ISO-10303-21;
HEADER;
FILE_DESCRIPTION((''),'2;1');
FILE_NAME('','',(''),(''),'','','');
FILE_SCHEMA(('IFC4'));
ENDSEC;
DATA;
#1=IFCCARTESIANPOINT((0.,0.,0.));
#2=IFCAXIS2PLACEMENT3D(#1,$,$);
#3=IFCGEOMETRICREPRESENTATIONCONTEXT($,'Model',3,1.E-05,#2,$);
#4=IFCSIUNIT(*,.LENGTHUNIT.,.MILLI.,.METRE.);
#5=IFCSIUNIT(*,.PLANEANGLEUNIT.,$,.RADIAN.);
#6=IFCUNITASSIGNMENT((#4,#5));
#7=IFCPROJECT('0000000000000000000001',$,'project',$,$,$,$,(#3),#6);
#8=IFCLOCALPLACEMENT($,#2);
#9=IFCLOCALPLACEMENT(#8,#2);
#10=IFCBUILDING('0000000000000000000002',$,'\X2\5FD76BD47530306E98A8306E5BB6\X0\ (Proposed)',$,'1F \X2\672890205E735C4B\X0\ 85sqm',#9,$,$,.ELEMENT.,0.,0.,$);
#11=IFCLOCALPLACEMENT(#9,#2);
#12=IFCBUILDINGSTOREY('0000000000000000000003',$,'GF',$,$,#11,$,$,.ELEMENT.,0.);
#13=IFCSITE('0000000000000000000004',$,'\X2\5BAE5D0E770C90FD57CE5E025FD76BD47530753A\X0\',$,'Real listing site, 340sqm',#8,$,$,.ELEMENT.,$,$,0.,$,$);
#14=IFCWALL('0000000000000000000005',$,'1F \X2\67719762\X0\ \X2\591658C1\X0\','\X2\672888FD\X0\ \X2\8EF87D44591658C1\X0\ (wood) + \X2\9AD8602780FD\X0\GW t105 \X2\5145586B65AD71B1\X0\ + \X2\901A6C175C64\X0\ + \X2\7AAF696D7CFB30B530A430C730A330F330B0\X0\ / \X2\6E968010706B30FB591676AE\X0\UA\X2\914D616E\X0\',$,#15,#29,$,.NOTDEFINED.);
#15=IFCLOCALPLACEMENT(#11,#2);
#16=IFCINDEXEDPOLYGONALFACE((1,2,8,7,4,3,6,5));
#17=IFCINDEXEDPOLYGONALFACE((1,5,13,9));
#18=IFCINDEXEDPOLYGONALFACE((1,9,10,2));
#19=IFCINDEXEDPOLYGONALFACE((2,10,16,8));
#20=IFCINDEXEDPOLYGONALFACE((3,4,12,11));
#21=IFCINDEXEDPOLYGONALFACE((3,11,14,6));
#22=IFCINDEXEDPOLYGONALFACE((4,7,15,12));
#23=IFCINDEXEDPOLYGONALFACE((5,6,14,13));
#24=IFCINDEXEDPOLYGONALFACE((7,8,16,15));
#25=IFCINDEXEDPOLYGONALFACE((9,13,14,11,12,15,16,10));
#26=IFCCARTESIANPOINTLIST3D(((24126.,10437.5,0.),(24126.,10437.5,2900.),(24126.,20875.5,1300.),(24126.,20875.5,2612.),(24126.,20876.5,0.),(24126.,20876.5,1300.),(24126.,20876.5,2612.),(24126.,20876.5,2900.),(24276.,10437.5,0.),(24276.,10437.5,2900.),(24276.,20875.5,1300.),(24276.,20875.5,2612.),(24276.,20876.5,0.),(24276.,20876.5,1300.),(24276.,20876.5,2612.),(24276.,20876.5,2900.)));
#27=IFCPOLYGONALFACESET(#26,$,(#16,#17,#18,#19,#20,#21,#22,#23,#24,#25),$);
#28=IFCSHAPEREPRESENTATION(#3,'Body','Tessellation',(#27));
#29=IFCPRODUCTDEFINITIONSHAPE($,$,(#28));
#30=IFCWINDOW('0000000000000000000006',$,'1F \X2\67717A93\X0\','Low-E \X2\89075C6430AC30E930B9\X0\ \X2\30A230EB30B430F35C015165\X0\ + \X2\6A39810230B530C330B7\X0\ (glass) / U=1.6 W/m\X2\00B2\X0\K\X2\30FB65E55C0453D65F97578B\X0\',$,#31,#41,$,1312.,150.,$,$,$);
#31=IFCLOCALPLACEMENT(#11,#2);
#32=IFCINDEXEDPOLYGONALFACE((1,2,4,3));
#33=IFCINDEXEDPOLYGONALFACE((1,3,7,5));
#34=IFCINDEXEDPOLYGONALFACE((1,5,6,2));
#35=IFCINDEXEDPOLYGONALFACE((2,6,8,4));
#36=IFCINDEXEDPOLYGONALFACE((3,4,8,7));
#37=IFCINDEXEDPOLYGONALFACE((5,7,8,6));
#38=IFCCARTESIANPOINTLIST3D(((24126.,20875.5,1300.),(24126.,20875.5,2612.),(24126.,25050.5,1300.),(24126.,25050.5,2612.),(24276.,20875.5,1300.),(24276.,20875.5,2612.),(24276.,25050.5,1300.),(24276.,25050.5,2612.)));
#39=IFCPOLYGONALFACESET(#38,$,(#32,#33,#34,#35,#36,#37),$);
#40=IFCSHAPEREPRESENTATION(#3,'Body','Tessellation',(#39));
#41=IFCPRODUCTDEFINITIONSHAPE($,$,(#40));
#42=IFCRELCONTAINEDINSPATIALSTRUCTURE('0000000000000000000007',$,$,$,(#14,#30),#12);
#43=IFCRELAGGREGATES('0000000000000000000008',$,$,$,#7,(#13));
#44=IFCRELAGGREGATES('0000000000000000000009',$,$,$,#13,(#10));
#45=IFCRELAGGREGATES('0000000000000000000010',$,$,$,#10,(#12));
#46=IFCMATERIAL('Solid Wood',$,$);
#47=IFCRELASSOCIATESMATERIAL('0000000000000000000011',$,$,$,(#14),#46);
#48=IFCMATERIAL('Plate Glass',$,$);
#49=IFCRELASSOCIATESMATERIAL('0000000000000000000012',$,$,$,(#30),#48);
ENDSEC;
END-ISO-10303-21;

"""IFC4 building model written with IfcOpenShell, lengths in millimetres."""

from ifc_helpers import new_model, si_unit, frame, frame_2d, origin, place, context, project, spatial, rectangle, extrude, material, element, fill, save


model = new_model("IFC4")

# Units and contexts
model_context = context("Model", 3, precision=1e-05, world=origin())
ifc_project = project(units=[si_unit("LENGTHUNIT", "METRE", prefix="MILLI"), si_unit("PLANEANGLEUNIT", "RADIAN")], contexts=[model_context])

# Site, building, storey
site_placement = place(None, origin())
site = spatial("IfcSite", under=ifc_project, at=site_placement, Name="宮崎県都城市志比田町", ObjectType="Real listing site, 340sqm", CompositionType="ELEMENT", RefElevation=0.0)
building_placement = place(site_placement, origin())
building = spatial("IfcBuilding", under=site, at=building_placement, Name="志比田の風の家 (Proposed)", ObjectType="1F 木造平屋 85sqm", CompositionType="ELEMENT", ElevationOfRefHeight=0.0, ElevationOfTerrain=0.0)
storey_placement = place(building_placement, origin())
storey = spatial("IfcBuildingStorey", under=building, at=storey_placement, Name="GF", CompositionType="ELEMENT", Elevation=0.0)

# Shared definitions
ifc_material_1 = material(Name="Solid Wood")

# Wall, opening, window
wall_1_placement = place(storey_placement, frame((12063.0, 5219.0, 0.0)))
wall_1 = element("IfcWall", 1, at=wall_1_placement, inside=storey, material=ifc_material_1, Name="1F 東面 外壁", Description="木製 軸組外壁 (wood) + 高性能GW t105 充填断熱 + 通気層 + 窯業系サイディング / 準耐火・外皮UA配慮", PredefinedType="NOTDEFINED", context=model_context, shape_type="SweptSolid", body=[
    extrude(rectangle(XDim=150.0, YDim=10439.0, at=frame_2d((75.0, 5219.0))), frame((12063.0, 5219.0, 0.0)), (0.0, 0.0, 1.0), 2900.0),
])
opening_placement = place(storey_placement, frame((12063.0, 10438.0, 650.0)))
opening = element("IfcOpeningElement", 2, at=opening_placement, cuts=wall_1, PredefinedType="NOTDEFINED", context=model_context, shape_type="SweptSolid", body=[
    extrude(rectangle(XDim=150.0, YDim=4175.0, at=frame_2d((75.0, 2087.0))), frame((12063.0, 10438.0, 650.0)), (0.0, 0.0, 1.0), 1312.0),
])
ifc_material_2 = material(Name="Plate Glass")
window_placement = place(storey_placement, frame((12063.0, 10438.0, 650.0)))
window = element("IfcWindow", 3, at=window_placement, inside=storey, material=ifc_material_2, Name="1F 東窓", Description="Low-E 複層ガラス アルゴン封入 + 樹脂サッシ (glass) / U=1.6 W/m²K・日射取得型", OverallHeight=1312.0, OverallWidth=150.0, context=model_context, shape_type="SweptSolid", body=[
    extrude(rectangle(XDim=150.0, YDim=4175.0, at=frame_2d((75.0, 2087.0))), frame((12063.0, 10438.0, 650.0)), (0.0, 0.0, 1.0), 1312.0),
])
fill(opening, window)

save(model, "model.ifc")
